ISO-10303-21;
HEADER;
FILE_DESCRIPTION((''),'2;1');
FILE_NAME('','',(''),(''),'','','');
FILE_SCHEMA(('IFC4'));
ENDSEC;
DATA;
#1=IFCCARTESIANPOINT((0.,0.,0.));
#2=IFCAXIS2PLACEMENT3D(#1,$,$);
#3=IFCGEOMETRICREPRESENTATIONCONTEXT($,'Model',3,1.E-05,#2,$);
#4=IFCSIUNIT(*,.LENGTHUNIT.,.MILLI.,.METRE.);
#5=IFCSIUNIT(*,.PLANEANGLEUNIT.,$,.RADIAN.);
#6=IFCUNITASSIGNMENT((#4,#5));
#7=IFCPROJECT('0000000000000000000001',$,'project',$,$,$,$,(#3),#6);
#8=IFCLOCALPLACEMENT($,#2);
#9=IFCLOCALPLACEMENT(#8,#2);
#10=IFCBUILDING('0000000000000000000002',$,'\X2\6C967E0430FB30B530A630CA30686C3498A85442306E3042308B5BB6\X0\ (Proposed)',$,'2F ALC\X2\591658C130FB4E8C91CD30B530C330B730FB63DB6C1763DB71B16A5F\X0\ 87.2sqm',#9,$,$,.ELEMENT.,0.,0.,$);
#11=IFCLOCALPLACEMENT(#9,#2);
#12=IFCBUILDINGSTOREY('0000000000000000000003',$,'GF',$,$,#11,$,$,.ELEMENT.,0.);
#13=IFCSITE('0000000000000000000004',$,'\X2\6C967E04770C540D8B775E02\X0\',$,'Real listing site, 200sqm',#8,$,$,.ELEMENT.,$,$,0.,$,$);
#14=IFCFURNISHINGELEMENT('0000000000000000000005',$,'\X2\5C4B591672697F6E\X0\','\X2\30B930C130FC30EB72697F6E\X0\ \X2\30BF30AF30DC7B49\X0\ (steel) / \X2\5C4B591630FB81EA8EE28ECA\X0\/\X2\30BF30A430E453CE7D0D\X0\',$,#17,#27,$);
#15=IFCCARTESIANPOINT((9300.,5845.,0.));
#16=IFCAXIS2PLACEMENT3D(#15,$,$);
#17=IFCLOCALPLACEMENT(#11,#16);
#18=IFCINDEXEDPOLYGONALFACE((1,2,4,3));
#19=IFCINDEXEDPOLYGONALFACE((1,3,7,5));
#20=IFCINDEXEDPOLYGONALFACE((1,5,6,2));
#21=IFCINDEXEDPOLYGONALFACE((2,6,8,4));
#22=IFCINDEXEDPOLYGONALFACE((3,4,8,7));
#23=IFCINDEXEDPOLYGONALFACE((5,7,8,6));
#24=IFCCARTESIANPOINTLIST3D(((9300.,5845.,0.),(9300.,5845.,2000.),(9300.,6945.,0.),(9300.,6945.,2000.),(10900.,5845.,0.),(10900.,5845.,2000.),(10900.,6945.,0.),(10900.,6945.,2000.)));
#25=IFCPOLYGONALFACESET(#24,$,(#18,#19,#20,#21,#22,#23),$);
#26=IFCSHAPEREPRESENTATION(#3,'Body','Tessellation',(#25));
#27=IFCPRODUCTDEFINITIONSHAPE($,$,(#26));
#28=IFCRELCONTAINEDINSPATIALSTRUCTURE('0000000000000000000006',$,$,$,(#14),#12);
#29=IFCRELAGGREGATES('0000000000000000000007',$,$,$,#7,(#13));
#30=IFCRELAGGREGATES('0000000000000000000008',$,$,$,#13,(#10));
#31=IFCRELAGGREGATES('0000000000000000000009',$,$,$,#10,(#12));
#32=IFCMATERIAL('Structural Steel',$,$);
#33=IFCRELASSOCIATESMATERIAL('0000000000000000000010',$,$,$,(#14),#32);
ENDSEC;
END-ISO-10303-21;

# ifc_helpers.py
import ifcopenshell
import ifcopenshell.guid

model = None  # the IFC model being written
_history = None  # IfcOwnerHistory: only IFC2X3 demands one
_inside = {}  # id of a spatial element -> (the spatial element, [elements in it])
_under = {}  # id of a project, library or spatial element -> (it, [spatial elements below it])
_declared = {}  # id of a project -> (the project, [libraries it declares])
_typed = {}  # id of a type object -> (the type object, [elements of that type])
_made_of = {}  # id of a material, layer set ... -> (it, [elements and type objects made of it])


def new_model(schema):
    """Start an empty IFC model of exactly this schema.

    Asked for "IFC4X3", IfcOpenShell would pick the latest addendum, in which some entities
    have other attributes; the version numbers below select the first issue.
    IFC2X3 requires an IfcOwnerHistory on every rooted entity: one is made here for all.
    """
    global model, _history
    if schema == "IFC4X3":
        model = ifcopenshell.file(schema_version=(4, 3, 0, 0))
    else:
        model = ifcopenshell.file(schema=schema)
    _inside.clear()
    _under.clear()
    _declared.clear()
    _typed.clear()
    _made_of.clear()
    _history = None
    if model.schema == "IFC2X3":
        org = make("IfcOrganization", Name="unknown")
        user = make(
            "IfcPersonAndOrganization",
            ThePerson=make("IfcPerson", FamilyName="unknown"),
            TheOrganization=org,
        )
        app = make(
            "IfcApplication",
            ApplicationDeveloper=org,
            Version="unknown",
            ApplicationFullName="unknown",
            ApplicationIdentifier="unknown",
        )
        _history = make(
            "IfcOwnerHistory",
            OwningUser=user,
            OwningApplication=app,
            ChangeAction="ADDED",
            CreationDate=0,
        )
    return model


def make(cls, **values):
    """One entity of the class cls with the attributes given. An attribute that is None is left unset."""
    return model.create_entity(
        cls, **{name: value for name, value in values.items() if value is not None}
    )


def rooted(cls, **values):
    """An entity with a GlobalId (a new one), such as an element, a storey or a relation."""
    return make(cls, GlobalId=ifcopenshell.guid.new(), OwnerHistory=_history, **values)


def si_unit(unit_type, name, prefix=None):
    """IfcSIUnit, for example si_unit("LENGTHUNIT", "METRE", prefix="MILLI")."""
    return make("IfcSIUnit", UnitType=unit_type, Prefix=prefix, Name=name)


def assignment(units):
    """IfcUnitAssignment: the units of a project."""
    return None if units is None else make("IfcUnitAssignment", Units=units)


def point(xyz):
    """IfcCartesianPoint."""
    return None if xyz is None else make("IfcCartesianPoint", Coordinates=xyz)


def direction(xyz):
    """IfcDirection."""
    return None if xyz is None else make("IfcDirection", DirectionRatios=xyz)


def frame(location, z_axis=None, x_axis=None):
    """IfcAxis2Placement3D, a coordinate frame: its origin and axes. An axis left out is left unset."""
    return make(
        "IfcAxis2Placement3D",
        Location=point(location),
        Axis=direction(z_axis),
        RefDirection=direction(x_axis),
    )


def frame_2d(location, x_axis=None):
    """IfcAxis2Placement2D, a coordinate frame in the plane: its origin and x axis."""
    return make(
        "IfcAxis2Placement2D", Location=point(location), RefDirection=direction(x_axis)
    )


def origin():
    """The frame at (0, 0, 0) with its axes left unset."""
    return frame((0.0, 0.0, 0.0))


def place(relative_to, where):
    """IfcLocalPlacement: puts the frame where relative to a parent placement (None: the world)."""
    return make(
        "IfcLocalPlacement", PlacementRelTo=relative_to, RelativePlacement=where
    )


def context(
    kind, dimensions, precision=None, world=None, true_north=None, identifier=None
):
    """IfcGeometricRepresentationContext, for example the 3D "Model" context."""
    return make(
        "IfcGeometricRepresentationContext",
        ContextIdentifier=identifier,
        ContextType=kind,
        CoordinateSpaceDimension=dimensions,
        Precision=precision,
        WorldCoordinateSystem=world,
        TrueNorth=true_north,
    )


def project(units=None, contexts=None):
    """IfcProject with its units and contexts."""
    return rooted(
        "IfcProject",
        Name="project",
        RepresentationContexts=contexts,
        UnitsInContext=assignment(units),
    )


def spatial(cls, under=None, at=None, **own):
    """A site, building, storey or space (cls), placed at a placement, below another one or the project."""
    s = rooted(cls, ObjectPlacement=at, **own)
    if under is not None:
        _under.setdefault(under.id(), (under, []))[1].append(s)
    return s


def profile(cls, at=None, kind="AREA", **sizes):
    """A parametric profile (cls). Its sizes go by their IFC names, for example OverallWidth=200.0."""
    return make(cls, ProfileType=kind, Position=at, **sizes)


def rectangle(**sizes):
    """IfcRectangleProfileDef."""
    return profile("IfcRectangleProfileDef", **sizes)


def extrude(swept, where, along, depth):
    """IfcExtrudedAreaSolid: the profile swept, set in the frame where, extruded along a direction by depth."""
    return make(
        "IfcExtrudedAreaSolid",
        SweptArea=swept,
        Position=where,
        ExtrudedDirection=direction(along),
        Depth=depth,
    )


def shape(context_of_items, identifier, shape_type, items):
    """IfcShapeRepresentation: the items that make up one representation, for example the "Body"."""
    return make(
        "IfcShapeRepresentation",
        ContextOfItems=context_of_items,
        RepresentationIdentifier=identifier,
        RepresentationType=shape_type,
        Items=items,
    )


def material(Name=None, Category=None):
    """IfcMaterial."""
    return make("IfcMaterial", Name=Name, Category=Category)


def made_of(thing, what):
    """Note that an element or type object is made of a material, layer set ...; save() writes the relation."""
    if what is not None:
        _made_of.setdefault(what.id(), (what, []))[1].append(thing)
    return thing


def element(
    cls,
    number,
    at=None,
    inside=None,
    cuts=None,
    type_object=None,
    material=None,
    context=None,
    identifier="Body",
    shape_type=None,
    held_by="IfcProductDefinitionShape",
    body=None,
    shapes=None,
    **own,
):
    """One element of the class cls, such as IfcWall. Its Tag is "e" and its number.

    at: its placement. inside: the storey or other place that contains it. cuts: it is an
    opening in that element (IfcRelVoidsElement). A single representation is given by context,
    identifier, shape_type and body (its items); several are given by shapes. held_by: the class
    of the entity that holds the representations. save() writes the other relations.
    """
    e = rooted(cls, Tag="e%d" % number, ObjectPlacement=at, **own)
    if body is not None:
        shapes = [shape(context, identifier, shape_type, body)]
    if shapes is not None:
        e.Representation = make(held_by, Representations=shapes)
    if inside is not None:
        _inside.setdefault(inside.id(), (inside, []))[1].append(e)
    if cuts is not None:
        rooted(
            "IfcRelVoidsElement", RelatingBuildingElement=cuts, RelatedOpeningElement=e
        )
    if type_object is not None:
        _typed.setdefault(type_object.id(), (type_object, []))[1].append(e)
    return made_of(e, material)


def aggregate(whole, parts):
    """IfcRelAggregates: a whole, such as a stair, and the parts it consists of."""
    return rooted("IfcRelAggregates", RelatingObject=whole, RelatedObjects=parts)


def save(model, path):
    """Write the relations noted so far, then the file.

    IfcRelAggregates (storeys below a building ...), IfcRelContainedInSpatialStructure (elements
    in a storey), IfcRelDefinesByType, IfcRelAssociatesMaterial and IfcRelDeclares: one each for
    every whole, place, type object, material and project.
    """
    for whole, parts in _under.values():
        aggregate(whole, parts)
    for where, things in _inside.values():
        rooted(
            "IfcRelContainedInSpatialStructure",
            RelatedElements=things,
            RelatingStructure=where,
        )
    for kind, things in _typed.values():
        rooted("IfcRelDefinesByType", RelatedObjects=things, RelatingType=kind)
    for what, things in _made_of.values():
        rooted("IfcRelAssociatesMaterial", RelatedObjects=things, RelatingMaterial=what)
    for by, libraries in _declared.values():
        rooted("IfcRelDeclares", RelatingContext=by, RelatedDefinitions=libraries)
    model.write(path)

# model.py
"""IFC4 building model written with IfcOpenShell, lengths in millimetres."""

from ifc_helpers import new_model, si_unit, frame, frame_2d, origin, place, context, project, spatial, rectangle, extrude, material, element, save


model = new_model("IFC4")

# Units and contexts
model_context = context("Model", 3, precision=1e-05, world=origin())
ifc_project = project(units=[si_unit("LENGTHUNIT", "METRE", prefix="MILLI"), si_unit("PLANEANGLEUNIT", "RADIAN")], contexts=[model_context])

# Site, building, storey
site_placement = place(None, origin())
site = spatial("IfcSite", under=ifc_project, at=site_placement, Name="沖縄県名護市", ObjectType="Real listing site, 200sqm", CompositionType="ELEMENT", RefElevation=0.0)
building_placement = place(site_placement, origin())
building = spatial("IfcBuilding", under=site, at=building_placement, Name="沖縄・サウナと水風呂のある家 (Proposed)", ObjectType="2F ALC外壁・二重サッシ・換気換熱機 87.2sqm", CompositionType="ELEMENT", ElevationOfRefHeight=0.0, ElevationOfTerrain=0.0)
storey_placement = place(building_placement, origin())
storey = spatial("IfcBuildingStorey", under=building, at=storey_placement, Name="GF", CompositionType="ELEMENT", Elevation=0.0)

# Shared definitions
ifc_material_1 = material(Name="Structural Steel")

# Furnishing element
furnishing_1_placement = place(storey_placement, frame((9300.0, 5845.0, 0.0)))
element("IfcFurnishingElement", 1, at=furnishing_1_placement, inside=storey, material=ifc_material_1, Name="屋外物置", Description="スチール物置 タクボ等 (steel) / 屋外・自転車/タイヤ収納", context=model_context, shape_type="SweptSolid", body=[
    extrude(rectangle(XDim=1600.0, YDim=1100.0, at=frame_2d((800.0, 550.0))), frame((9300.0, 5845.0, 0.0)), (0.0, 0.0, 1.0), 2000.0),
])

save(model, "model.ifc")
